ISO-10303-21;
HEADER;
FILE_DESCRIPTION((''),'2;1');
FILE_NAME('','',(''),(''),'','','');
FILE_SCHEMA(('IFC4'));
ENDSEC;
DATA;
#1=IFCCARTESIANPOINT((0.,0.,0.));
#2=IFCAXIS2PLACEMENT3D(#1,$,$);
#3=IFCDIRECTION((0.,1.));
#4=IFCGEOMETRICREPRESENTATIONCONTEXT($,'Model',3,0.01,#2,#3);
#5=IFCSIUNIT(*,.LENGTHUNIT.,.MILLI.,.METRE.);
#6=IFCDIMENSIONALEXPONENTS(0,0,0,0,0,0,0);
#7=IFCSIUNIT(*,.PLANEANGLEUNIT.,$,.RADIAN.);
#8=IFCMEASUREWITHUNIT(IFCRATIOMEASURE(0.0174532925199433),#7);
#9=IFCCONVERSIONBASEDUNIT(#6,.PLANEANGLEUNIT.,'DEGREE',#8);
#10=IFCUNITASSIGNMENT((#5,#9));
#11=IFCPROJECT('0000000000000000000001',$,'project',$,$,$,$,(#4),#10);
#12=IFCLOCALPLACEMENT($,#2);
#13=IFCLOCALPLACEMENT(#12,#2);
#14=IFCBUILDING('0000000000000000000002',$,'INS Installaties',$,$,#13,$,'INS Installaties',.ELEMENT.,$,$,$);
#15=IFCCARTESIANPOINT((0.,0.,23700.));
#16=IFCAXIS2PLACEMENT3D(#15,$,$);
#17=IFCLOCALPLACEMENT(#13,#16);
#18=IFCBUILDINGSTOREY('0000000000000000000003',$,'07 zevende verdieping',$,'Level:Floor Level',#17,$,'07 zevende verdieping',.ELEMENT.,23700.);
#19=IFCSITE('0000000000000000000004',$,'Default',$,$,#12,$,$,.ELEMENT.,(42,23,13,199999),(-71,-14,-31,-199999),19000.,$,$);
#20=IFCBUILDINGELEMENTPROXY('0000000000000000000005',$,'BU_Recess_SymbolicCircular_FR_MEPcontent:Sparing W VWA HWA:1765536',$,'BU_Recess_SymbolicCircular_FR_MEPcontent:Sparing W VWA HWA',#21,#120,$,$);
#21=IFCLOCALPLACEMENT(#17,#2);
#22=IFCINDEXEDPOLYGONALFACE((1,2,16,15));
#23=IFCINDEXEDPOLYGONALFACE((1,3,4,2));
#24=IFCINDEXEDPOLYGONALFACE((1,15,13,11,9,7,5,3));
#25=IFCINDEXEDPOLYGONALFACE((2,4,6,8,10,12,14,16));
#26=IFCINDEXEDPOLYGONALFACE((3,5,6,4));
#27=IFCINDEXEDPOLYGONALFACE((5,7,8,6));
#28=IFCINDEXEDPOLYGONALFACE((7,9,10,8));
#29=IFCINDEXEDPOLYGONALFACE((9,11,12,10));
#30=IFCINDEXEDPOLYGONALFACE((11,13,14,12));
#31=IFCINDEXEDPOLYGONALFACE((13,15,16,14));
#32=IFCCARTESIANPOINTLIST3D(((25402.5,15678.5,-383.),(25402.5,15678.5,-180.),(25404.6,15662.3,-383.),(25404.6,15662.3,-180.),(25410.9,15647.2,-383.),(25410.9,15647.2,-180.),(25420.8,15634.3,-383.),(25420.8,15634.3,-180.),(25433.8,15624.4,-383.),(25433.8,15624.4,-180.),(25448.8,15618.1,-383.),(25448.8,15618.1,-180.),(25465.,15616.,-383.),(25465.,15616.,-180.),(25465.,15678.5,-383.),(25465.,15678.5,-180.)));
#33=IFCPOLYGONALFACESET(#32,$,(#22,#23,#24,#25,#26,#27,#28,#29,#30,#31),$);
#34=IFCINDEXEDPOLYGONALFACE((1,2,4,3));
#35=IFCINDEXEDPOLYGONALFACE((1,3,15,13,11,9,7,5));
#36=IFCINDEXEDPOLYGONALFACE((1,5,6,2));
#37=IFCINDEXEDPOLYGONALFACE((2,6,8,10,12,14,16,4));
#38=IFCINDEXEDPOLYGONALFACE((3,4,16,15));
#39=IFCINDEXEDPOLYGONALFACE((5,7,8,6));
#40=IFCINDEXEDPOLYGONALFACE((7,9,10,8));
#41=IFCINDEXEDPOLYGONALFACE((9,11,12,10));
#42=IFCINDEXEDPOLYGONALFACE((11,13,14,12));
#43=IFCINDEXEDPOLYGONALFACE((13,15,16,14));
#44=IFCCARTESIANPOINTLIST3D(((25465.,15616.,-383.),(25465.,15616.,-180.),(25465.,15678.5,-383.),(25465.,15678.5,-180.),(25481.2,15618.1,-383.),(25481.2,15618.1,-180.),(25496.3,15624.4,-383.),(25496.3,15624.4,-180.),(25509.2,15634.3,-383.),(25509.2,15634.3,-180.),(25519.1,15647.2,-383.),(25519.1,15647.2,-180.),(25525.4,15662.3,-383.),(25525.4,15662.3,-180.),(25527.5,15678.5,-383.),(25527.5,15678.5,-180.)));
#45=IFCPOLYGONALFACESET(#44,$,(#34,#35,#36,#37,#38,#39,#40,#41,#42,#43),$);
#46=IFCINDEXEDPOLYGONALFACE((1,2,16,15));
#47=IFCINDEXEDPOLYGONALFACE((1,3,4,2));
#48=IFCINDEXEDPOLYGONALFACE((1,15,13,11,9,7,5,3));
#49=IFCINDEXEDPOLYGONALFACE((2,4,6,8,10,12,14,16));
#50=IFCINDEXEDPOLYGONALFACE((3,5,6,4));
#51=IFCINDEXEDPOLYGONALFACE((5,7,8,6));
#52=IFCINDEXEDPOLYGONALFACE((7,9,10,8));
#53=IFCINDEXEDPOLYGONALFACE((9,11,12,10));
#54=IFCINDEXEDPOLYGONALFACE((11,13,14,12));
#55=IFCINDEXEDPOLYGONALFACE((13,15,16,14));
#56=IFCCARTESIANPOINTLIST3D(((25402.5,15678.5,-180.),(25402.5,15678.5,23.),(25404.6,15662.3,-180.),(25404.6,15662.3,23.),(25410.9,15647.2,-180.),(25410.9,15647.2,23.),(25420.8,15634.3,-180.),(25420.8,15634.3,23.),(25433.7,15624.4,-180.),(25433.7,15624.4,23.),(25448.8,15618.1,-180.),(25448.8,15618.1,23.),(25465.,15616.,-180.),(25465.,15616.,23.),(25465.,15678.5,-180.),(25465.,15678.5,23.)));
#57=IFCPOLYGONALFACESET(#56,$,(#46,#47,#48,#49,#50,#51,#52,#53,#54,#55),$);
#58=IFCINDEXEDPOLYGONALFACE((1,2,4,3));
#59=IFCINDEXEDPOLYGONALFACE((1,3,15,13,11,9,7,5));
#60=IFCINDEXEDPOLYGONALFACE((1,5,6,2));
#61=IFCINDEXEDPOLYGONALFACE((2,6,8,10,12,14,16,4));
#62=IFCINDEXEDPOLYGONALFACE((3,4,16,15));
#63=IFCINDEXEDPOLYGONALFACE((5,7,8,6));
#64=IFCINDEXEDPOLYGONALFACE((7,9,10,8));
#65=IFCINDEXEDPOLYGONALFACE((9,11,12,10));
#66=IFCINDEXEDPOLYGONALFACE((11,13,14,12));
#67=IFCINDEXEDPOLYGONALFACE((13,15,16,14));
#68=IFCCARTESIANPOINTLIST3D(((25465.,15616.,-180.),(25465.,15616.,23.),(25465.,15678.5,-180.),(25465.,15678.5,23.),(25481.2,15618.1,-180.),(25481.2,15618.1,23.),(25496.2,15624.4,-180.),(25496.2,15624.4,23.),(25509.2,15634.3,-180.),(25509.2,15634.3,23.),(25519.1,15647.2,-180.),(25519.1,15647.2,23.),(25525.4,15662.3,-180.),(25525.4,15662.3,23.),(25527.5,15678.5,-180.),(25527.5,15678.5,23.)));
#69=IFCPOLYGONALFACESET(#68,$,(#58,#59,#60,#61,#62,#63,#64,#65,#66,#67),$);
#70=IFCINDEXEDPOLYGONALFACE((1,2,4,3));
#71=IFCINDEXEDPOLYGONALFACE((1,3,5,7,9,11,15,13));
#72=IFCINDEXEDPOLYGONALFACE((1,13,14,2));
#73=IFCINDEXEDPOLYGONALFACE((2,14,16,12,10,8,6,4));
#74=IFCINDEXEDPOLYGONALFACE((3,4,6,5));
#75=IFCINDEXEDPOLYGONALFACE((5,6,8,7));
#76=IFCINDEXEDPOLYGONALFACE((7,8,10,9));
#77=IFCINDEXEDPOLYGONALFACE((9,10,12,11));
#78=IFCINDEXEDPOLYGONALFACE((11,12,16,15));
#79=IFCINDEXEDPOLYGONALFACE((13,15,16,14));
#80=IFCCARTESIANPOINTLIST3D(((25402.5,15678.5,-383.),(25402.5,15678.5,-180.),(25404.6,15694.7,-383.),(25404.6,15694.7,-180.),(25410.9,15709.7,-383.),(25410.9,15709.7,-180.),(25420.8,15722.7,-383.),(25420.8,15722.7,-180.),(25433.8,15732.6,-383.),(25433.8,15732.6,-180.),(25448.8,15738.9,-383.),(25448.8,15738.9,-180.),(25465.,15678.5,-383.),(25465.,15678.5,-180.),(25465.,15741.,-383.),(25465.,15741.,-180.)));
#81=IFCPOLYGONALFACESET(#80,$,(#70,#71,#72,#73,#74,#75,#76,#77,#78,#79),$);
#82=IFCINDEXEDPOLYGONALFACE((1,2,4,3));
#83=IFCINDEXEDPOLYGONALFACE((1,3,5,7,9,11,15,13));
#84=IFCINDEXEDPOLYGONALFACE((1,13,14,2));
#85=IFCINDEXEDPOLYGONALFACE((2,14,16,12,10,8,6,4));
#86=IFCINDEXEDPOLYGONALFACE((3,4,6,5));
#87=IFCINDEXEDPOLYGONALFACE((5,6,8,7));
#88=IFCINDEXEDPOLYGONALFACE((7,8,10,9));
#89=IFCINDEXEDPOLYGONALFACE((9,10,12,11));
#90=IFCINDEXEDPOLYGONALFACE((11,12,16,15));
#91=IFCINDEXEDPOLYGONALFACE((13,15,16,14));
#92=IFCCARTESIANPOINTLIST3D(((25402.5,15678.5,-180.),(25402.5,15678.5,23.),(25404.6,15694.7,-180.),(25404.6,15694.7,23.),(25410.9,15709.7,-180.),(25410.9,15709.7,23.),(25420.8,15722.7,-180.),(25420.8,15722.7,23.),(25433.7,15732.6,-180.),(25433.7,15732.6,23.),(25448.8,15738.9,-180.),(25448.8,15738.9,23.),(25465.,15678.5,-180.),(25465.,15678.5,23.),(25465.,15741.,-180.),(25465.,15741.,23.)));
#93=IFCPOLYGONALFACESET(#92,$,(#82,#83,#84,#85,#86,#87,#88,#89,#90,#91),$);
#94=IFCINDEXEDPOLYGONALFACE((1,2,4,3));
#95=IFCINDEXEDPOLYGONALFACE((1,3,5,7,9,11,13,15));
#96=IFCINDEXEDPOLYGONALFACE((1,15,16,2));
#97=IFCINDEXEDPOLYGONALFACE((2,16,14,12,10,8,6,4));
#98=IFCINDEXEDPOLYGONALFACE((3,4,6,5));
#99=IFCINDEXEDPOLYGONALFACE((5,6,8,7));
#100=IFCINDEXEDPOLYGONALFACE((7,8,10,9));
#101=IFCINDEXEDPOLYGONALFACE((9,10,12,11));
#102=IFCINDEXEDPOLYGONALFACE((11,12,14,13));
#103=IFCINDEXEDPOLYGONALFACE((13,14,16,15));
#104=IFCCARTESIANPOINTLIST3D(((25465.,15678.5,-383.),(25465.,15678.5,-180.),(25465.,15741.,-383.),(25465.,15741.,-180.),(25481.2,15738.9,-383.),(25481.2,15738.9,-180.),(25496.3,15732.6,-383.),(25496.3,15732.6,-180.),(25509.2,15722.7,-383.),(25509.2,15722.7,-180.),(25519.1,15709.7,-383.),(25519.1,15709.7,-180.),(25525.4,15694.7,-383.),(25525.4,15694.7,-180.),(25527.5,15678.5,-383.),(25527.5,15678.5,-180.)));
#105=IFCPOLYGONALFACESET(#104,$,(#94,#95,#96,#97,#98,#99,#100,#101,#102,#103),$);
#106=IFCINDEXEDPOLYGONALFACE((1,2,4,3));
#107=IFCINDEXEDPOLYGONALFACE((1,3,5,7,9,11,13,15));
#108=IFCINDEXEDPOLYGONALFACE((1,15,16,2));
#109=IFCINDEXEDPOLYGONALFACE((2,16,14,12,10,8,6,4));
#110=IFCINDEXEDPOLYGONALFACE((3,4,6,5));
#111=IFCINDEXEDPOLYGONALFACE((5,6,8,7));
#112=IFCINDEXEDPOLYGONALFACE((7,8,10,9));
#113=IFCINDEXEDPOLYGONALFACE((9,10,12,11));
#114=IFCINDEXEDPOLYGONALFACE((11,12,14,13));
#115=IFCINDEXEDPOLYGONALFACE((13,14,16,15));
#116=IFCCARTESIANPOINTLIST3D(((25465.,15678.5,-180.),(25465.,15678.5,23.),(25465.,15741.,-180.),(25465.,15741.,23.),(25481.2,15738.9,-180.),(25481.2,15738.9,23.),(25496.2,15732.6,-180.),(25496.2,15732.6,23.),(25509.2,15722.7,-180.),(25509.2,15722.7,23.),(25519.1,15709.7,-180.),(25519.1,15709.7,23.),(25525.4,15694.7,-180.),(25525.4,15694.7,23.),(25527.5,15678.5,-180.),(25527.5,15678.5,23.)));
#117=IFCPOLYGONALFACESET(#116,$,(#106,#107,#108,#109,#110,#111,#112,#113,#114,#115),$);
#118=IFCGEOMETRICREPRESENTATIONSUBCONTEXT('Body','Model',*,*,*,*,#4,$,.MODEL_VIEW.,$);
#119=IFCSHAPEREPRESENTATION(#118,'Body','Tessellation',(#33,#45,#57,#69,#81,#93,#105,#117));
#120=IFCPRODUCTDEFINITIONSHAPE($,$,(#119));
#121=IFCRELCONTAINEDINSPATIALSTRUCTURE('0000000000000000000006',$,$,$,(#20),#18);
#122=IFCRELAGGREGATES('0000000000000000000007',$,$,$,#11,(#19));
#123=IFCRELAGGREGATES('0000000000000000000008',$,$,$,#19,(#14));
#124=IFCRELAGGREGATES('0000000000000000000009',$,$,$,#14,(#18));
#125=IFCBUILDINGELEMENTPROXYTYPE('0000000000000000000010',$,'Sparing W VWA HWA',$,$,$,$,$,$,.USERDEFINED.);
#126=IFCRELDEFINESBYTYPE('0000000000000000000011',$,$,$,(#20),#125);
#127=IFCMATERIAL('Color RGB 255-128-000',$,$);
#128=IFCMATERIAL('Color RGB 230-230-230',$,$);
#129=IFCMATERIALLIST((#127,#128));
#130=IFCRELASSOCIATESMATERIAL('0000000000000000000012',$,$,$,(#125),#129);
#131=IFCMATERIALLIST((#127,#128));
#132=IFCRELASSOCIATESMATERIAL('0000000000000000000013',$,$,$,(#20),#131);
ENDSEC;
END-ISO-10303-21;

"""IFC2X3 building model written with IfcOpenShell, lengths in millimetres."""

from ifc_helpers import new_model, entity, si_unit, converted_unit, direction, frame, frame_2d, origin, place, context, subcontext, project, spatial, polyline, circle_curve, parameter, trimmed, segment, composite_curve, outline, extrude, source, transform, mapped, material, material_list, type_object, type_shapes, element, save


model = new_model("IFC2X3")

# Units and contexts
model_context = context("Model", 3, precision=0.01, world=origin(), true_north=direction((0.0, 1.0)))
body_context = subcontext(model_context, "Body", "Model", "MODEL_VIEW")
ifc_project = project(units=[si_unit("LENGTHUNIT", "METRE", prefix="MILLI"), converted_unit("PLANEANGLEUNIT", "DEGREE", entity("IfcRatioMeasure", 0.0174532925199433), si_unit("PLANEANGLEUNIT", "RADIAN"), dimensions=[0, 0, 0, 0, 0, 0, 0])], contexts=[model_context])

# Site, building, storey
site_placement = place(None, origin())
site = spatial("IfcSite", under=ifc_project, at=site_placement, Name="Default", CompositionType="ELEMENT", RefLatitude=(42, 23, 13, 199999), RefLongitude=(-71, -14, -31, -199999), RefElevation=19000.0)
building_placement = place(site_placement, origin())
building = spatial("IfcBuilding", under=site, at=building_placement, Name="INS Installaties", LongName="INS Installaties", CompositionType="ELEMENT")
storey_placement = place(building_placement, frame((0.0, 0.0, 23700.0)))
storey = spatial("IfcBuildingStorey", under=building, at=storey_placement, Name="07 zevende verdieping", ObjectType="Level:Floor Level", LongName="07 zevende verdieping", CompositionType="ELEMENT", Elevation=23700.0)

# Building element proxy
ifc_material_1 = material(Name="Color RGB 255-128-000")
ifc_material_2 = material(Name="Color RGB 230-230-230")
ifc_material_list_1 = material_list([ifc_material_1, ifc_material_2])
building_element_proxy_type_1 = type_object("IfcBuildingElementProxyType", Name="Sparing W VWA HWA", PredefinedType="USERDEFINED", material=ifc_material_list_1)
shared_shape_1 = source(origin(), body_context, "Body", "SweptSolid", [
    extrude(outline(composite_curve([segment(trimmed(circle_curve(frame_2d((20.8, 20.8), x_axis=(1.0, 0.0)), 62.5), [parameter(180.0)], [parameter(270.0)], True, "PARAMETER"), True, "CONTINUOUS"), segment(polyline([(20.8, -41.7), (20.8, 20.8)]), True, "CONTINUOUS"), segment(polyline([(20.8, 20.8), (-41.7, 20.8)]), True, "CONTINUOUS")], self_intersect=False)), frame((20.8, 20.8, -403.0), z_axis=(0.0, 0.0, 1.0), x_axis=(-1.0, 0.0, 0.0)), (0.0, 0.0, 1.0), 203.0),
    extrude(outline(composite_curve([segment(polyline([(-41.7, -20.8), (20.8, -20.8)]), True, "CONTINUOUS"), segment(polyline([(20.8, -20.8), (20.8, 41.7)]), True, "CONTINUOUS"), segment(trimmed(circle_curve(frame_2d((20.8, -20.8), x_axis=(1.0, 0.0)), 62.5), [parameter(90.0)], [parameter(180.0)], True, "PARAMETER"), True, "CONTINUOUS")], self_intersect=False)), frame((-20.8, 20.8, -403.0)), (0.0, 0.0, 1.0), 203.0),
    extrude(outline(composite_curve([segment(trimmed(circle_curve(frame_2d((20.8, 20.8), x_axis=(1.0, 0.0)), 62.5), [parameter(180.0)], [parameter(270.0)], True, "PARAMETER"), True, "CONTINUOUS"), segment(polyline([(20.8, -41.7), (20.8, 20.8)]), True, "CONTINUOUS"), segment(polyline([(20.8, 20.8), (-41.7, 20.8)]), True, "CONTINUOUS")], self_intersect=False)), frame((20.8, 20.8, -200.0), z_axis=(0.0, 0.0, 1.0), x_axis=(-1.0, 0.0, 0.0)), (0.0, 0.0, 1.0), 203.0),
    extrude(outline(composite_curve([segment(polyline([(-41.7, -20.8), (20.8, -20.8)]), True, "CONTINUOUS"), segment(polyline([(20.8, -20.8), (20.8, 41.7)]), True, "CONTINUOUS"), segment(trimmed(circle_curve(frame_2d((20.8, -20.8), x_axis=(1.0, 0.0)), 62.5), [parameter(90.0)], [parameter(180.0)], True, "PARAMETER"), True, "CONTINUOUS")], self_intersect=False)), frame((-20.8, 20.8, -200.0)), (0.0, 0.0, 1.0), 203.0),
    extrude(outline(composite_curve([segment(polyline([(-41.7, -20.8), (20.8, -20.8)]), True, "CONTINUOUS"), segment(polyline([(20.8, -20.8), (20.8, 41.7)]), True, "CONTINUOUS"), segment(trimmed(circle_curve(frame_2d((20.8, -20.8), x_axis=(1.0, 0.0)), 62.5), [parameter(90.0)], [parameter(180.0)], True, "PARAMETER"), True, "CONTINUOUS")], self_intersect=False)), frame((20.8, -20.8, -403.0), z_axis=(0.0, 0.0, 1.0), x_axis=(-1.0, 0.0, 0.0)), (0.0, 0.0, 1.0), 203.0),
    extrude(outline(composite_curve([segment(polyline([(-41.7, -20.8), (20.8, -20.8)]), True, "CONTINUOUS"), segment(polyline([(20.8, -20.8), (20.8, 41.7)]), True, "CONTINUOUS"), segment(trimmed(circle_curve(frame_2d((20.8, -20.8), x_axis=(1.0, 0.0)), 62.5), [parameter(90.0)], [parameter(180.0)], True, "PARAMETER"), True, "CONTINUOUS")], self_intersect=False)), frame((20.8, -20.8, -200.0), z_axis=(0.0, 0.0, 1.0), x_axis=(-1.0, 0.0, 0.0)), (0.0, 0.0, 1.0), 203.0),
    extrude(outline(composite_curve([segment(trimmed(circle_curve(frame_2d((20.8, 20.8), x_axis=(1.0, 0.0)), 62.5), [parameter(180.0)], [parameter(270.0)], True, "PARAMETER"), True, "CONTINUOUS"), segment(polyline([(20.8, -41.7), (20.8, 20.8)]), True, "CONTINUOUS"), segment(polyline([(20.8, 20.8), (-41.7, 20.8)]), True, "CONTINUOUS")], self_intersect=False)), frame((-20.8, -20.8, -403.0)), (0.0, 0.0, 1.0), 203.0),
    extrude(outline(composite_curve([segment(trimmed(circle_curve(frame_2d((20.8, 20.8), x_axis=(1.0, 0.0)), 62.5), [parameter(180.0)], [parameter(270.0)], True, "PARAMETER"), True, "CONTINUOUS"), segment(polyline([(20.8, -41.7), (20.8, 20.8)]), True, "CONTINUOUS"), segment(polyline([(20.8, 20.8), (-41.7, 20.8)]), True, "CONTINUOUS")], self_intersect=False)), frame((-20.8, -20.8, -200.0)), (0.0, 0.0, 1.0), 203.0),
])
type_shapes(building_element_proxy_type_1, [shared_shape_1])
ifc_material_list_2 = material_list([ifc_material_1, ifc_material_2])
proxy_1_placement = place(storey_placement, frame((25465.0, 15678.5, 20.0), z_axis=(0.0, 0.0, 1.0), x_axis=(-1.0, 0.0, 0.0)))
element("IfcBuildingElementProxy", 1, at=proxy_1_placement, inside=storey, type_object=building_element_proxy_type_1, material=ifc_material_list_2, Name="BU_Recess_SymbolicCircular_FR_MEPcontent:Sparing W VWA HWA:1765536", ObjectType="BU_Recess_SymbolicCircular_FR_MEPcontent:Sparing W VWA HWA", context=body_context, shape_type="MappedRepresentation", body=[
    mapped(shared_shape_1, transform((0.0, 0.0, 0.0), scale=1.0)),
])

save(model, "model.ifc")
